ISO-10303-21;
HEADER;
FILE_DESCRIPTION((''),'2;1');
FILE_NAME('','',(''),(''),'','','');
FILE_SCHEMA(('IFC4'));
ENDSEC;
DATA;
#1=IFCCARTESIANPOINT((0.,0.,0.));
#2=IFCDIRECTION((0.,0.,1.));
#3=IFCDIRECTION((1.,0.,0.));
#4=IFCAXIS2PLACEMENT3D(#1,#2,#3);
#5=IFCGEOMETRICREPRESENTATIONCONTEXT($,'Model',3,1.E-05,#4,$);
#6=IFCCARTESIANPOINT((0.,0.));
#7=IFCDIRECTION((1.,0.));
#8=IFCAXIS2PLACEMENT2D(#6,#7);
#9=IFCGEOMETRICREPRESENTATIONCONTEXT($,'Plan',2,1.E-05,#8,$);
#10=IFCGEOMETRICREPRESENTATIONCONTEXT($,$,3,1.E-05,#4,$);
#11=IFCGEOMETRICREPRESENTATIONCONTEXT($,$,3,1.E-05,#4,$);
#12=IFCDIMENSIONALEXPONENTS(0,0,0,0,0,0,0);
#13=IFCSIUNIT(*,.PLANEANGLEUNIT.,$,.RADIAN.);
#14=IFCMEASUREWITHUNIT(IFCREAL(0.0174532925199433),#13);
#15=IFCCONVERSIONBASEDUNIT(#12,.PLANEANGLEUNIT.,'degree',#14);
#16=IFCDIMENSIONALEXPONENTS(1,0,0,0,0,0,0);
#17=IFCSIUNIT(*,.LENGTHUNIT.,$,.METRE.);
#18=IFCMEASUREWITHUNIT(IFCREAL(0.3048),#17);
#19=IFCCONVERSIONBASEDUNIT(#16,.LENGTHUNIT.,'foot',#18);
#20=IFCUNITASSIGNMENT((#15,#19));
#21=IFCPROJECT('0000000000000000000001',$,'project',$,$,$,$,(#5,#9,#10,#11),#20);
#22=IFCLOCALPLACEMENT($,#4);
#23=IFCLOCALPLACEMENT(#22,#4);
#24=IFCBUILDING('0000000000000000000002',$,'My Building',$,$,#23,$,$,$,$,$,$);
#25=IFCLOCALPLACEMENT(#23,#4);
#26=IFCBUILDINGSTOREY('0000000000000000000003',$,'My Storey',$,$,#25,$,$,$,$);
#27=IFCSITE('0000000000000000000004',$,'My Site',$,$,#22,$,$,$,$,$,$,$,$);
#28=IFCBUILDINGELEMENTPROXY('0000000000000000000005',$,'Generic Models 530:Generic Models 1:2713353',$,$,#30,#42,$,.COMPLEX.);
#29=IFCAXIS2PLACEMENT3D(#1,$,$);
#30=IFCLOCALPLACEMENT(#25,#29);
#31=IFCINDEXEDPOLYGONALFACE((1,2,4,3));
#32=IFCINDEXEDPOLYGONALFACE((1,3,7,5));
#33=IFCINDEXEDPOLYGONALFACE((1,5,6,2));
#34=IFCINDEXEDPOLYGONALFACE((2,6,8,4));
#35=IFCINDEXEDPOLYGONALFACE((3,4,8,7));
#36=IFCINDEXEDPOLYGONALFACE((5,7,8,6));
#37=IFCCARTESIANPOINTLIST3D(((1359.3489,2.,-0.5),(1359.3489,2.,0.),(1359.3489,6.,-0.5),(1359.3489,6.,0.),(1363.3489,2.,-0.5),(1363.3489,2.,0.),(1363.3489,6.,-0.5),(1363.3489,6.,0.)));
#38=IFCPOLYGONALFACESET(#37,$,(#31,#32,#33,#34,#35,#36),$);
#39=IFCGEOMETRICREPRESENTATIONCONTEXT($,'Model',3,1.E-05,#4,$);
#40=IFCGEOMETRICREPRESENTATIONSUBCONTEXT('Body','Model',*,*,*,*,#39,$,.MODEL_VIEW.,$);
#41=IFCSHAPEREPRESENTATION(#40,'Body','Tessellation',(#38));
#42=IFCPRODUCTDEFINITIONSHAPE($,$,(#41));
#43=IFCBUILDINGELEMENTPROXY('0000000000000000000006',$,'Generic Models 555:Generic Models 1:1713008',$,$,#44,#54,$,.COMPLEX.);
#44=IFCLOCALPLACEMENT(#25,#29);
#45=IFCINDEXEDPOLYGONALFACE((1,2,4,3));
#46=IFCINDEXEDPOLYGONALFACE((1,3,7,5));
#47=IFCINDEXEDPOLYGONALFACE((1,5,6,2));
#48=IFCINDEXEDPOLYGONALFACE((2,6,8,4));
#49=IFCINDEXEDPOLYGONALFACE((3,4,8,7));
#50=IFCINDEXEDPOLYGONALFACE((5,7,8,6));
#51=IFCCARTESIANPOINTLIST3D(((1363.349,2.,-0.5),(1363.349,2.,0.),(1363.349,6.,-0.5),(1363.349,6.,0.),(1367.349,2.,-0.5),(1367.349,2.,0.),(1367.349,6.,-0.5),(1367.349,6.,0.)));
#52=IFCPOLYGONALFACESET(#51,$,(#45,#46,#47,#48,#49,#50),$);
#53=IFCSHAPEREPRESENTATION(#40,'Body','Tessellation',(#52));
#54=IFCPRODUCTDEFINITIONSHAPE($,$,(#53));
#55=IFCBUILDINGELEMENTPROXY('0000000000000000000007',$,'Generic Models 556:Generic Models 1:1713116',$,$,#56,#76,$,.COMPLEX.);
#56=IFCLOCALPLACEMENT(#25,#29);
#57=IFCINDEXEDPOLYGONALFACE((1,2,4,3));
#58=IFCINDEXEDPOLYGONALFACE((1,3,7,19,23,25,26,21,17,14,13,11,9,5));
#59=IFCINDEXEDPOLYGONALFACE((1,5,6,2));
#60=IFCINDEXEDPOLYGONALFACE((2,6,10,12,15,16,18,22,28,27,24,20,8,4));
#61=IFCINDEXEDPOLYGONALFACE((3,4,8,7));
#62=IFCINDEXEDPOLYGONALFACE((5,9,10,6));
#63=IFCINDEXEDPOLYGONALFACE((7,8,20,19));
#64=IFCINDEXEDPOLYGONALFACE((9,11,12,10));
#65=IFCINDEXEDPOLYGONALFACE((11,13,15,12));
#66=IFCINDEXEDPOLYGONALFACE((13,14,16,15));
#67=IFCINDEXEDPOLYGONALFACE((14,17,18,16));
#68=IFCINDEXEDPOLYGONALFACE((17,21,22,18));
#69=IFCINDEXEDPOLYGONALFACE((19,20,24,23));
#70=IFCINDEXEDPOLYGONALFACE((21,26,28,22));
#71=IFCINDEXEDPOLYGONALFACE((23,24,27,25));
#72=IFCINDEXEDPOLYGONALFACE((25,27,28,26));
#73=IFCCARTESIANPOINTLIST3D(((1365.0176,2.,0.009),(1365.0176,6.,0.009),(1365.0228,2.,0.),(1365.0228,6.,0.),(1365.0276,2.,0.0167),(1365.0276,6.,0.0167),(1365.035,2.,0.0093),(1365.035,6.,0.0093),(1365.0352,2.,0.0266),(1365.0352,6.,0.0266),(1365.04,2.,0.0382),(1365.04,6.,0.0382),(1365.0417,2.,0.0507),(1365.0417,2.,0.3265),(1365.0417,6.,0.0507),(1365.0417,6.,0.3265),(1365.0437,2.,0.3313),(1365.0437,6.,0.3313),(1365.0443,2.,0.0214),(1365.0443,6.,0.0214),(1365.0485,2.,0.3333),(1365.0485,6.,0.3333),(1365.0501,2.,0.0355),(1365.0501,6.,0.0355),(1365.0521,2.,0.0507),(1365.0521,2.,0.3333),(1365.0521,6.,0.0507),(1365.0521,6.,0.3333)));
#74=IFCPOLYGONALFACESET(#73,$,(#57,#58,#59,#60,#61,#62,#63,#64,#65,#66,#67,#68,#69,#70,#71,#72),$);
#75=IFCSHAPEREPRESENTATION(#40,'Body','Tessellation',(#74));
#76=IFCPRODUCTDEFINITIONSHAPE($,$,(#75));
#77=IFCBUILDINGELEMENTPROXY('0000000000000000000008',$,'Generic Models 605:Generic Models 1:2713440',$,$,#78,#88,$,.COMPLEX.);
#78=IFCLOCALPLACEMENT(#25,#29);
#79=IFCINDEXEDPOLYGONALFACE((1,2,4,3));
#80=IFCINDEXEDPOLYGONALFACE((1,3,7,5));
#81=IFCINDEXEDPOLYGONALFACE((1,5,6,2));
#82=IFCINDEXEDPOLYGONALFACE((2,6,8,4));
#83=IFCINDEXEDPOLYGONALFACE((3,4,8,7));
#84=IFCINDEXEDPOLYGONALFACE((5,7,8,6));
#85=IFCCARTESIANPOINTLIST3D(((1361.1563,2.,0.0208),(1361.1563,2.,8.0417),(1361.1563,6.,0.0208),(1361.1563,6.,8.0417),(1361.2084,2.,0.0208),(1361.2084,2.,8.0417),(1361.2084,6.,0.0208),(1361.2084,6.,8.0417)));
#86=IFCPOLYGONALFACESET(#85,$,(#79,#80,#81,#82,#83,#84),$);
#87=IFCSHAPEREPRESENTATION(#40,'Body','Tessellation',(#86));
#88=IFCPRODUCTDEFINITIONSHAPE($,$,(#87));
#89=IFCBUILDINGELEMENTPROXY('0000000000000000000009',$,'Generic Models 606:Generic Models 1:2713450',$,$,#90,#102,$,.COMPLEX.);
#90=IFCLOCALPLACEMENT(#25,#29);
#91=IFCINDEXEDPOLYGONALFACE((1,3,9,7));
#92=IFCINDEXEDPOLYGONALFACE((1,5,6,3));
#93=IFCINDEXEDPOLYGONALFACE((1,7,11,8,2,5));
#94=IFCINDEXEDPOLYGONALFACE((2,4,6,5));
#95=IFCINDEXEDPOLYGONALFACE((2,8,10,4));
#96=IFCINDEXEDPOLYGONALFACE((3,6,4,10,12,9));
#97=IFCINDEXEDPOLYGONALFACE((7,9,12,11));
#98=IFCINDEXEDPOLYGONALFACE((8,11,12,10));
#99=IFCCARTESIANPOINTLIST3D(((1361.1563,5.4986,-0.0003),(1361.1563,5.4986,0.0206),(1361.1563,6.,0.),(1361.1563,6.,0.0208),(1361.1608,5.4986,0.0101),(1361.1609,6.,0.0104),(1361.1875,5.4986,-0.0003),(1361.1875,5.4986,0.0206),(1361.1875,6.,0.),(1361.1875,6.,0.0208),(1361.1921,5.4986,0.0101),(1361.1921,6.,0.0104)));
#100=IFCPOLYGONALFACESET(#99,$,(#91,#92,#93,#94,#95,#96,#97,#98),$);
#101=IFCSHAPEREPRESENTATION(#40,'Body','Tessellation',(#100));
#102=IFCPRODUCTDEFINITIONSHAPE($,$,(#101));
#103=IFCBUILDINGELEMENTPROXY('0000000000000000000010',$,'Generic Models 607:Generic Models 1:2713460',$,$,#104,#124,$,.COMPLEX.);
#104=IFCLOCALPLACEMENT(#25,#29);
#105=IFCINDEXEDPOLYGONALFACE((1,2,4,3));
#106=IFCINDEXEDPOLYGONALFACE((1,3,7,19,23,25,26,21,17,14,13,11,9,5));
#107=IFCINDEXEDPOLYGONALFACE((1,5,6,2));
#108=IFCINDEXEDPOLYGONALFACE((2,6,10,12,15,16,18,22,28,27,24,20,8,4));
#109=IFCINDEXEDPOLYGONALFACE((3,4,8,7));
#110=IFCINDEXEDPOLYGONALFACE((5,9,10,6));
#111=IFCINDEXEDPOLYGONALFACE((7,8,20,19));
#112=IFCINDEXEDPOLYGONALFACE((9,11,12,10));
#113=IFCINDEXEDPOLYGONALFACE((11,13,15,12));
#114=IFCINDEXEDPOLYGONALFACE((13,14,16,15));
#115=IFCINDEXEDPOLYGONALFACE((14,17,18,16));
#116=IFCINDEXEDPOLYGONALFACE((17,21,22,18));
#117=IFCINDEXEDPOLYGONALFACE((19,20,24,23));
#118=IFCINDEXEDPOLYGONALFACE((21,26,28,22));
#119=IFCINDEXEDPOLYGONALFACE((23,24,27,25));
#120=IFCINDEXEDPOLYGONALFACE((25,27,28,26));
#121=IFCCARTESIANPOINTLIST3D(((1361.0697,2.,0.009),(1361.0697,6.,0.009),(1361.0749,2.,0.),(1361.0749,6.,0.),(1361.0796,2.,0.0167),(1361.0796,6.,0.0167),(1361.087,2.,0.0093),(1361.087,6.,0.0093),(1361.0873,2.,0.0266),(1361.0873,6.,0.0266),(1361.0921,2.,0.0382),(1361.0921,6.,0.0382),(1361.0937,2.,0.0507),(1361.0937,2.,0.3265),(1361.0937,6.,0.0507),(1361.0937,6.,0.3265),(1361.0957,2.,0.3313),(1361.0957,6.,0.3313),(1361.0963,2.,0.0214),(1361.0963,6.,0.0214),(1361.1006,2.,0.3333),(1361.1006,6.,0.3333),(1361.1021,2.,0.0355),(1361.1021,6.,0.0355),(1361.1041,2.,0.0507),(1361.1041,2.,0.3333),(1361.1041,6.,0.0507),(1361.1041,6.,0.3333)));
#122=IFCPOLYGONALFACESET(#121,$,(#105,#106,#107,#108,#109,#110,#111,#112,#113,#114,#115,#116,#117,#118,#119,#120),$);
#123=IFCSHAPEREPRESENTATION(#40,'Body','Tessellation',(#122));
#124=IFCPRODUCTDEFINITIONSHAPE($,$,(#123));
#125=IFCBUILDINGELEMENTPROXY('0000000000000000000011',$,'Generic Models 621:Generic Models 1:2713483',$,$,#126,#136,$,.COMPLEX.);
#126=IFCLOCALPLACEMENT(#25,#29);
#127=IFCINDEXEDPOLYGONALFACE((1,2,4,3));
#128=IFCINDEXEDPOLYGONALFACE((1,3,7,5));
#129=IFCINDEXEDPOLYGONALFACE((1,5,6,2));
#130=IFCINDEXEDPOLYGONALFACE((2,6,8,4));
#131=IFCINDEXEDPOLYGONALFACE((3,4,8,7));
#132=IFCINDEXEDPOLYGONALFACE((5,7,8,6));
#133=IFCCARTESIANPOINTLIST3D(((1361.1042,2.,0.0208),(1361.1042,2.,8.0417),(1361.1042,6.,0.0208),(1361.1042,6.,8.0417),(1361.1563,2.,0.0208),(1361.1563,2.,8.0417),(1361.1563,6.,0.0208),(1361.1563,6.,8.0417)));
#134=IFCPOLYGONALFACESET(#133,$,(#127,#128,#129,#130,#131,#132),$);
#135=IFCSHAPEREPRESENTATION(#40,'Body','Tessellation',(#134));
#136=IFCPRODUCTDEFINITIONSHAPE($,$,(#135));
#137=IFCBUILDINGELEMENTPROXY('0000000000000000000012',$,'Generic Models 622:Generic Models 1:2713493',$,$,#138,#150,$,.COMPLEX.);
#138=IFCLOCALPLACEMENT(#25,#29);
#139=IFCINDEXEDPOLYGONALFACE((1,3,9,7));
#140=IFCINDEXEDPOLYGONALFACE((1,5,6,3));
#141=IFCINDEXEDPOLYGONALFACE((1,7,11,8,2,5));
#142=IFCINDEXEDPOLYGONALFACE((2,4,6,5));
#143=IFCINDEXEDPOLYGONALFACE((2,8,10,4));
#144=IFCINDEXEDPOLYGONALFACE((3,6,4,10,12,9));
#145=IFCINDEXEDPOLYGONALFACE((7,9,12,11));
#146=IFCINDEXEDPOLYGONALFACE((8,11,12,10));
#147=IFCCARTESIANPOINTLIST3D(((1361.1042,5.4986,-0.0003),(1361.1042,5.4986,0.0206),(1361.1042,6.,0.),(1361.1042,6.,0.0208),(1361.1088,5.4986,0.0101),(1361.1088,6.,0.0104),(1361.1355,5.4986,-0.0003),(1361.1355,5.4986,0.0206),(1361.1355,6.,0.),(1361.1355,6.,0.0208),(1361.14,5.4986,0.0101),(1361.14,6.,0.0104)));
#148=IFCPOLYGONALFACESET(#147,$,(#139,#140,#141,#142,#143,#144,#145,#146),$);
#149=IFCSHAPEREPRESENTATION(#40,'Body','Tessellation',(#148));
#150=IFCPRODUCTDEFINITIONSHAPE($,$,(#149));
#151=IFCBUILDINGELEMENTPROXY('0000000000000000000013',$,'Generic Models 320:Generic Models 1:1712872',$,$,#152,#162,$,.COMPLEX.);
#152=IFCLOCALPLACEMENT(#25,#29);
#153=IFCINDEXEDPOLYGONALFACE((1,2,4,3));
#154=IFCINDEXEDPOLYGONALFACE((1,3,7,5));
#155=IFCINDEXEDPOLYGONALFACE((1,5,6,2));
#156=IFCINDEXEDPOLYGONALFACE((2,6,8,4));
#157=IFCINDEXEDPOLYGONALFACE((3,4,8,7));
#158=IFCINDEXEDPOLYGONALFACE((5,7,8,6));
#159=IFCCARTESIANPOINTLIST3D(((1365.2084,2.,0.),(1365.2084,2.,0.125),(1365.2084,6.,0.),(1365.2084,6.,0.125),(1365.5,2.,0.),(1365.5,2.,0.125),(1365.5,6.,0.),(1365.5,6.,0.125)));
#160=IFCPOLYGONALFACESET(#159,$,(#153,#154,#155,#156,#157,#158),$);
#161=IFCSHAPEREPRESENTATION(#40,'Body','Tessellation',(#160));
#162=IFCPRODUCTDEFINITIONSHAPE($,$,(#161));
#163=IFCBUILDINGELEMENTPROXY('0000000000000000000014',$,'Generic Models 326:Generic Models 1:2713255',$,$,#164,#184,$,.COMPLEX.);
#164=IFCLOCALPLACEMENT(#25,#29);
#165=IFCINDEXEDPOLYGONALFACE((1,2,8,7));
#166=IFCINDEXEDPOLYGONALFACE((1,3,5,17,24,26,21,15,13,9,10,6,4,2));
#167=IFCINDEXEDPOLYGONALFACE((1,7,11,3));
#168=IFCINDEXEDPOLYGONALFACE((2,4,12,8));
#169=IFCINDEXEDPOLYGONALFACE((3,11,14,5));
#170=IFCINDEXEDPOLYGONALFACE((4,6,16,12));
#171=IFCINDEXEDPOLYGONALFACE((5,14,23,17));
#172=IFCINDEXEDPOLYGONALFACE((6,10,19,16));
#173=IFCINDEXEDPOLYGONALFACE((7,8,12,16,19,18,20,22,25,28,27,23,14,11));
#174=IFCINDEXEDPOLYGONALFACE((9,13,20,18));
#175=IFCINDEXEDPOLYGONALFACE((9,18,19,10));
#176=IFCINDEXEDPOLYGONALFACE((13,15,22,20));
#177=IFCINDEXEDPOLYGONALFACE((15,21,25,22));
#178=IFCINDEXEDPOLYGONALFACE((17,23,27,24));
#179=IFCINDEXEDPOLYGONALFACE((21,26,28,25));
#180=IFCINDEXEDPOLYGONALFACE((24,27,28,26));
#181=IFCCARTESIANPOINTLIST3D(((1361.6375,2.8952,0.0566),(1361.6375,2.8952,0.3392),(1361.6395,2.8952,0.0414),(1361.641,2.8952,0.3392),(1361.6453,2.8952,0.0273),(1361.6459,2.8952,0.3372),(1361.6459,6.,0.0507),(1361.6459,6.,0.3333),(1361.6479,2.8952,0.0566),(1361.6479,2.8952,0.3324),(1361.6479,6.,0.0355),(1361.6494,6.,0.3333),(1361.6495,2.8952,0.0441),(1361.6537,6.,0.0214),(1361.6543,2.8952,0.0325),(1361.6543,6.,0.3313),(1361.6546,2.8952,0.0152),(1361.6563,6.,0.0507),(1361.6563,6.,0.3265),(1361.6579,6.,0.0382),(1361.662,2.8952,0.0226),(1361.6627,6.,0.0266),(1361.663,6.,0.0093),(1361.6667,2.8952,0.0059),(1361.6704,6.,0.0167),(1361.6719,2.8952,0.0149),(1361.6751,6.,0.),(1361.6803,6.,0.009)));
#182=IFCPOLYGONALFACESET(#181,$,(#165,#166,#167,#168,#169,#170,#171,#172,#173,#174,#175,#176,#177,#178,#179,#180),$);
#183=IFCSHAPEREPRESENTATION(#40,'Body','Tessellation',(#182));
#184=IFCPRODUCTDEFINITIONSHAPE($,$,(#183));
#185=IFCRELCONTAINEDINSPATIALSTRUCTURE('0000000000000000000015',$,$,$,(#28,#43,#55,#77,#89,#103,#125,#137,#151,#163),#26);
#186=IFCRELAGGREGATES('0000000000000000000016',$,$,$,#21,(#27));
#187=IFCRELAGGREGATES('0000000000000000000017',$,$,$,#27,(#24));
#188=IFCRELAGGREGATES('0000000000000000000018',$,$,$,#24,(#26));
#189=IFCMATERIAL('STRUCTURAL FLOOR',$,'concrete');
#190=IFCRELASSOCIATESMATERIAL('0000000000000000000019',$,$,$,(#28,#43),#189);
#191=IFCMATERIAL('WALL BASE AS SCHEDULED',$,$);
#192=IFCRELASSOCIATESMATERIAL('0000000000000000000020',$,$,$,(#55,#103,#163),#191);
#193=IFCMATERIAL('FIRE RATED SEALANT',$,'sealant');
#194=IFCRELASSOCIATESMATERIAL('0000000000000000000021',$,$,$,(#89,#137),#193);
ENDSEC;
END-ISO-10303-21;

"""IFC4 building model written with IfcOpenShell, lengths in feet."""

from ifc_helpers import new_model, entity, si_unit, converted_unit, frame, origin_with_axes, origin_2d_with_axis, place, context, subcontext, project, spatial, polyline, outline, extrude, material, element, save


model = new_model("IFC4")

# Units and contexts
model_context_1 = context("Model", 3, precision=1e-05, world=origin_with_axes())
plan_context = context("Plan", 2, precision=1e-05, world=origin_2d_with_axis())
model_context_2 = context("Model", 3, precision=1e-05, world=origin_with_axes())
context_of_model_1 = context(None, 3, precision=1e-05, world=origin_with_axes())
context_of_model_2 = context(None, 3, precision=1e-05, world=origin_with_axes())
body_context = subcontext(model_context_2, "Body", "Model", "MODEL_VIEW")
ifc_project = project(units=[converted_unit("PLANEANGLEUNIT", "degree", entity("IfcReal", 0.0174532925199433), si_unit("PLANEANGLEUNIT", "RADIAN"), dimensions=[0, 0, 0, 0, 0, 0, 0]), converted_unit("LENGTHUNIT", "foot", entity("IfcReal", 0.3048), si_unit("LENGTHUNIT", "METRE"), dimensions=[1, 0, 0, 0, 0, 0, 0])], contexts=[model_context_1, plan_context, context_of_model_1, context_of_model_2])

# Site, building, storey
site_placement = place(None, origin_with_axes())
site = spatial("IfcSite", under=ifc_project, at=site_placement, Name="My Site")
building_placement = place(site_placement, origin_with_axes())
building = spatial("IfcBuilding", under=site, at=building_placement, Name="My Building")
storey_placement = place(building_placement, origin_with_axes())
storey = spatial("IfcBuildingStorey", under=building, at=storey_placement, Name="My Storey")

# Building element proxies
ifc_material_1 = material(Name="STRUCTURAL FLOOR", Category="concrete")
proxy_1_placement = place(storey_placement, frame((1359.3489, 6.0, -0.5), z_axis=(0.0, -1.0, 0.0), x_axis=(0.0, 0.0, 1.0)))
element("IfcBuildingElementProxy", 1, at=proxy_1_placement, inside=storey, material=ifc_material_1, Name="Generic Models 530:Generic Models 1:2713353", PredefinedType="COMPLEX", context=body_context, shape_type="SweptSolid", body=[
    extrude(outline(polyline([(-0.25, -2.0), (0.25, -2.0), (0.25, 2.0), (-0.25, 2.0), (-0.25, -2.0)])), frame((0.25, -2.0, 0.0), z_axis=(0.0, 0.0, -1.0), x_axis=(1.0, 0.0, 0.0)), (0.0, 0.0, -1.0), 4.0),
])
proxy_2_placement = place(storey_placement, frame((1363.349, 6.0, -0.5), z_axis=(0.0, -1.0, 0.0), x_axis=(0.0, 0.0, 1.0)))
element("IfcBuildingElementProxy", 2, at=proxy_2_placement, inside=storey, material=ifc_material_1, Name="Generic Models 555:Generic Models 1:1713008", PredefinedType="COMPLEX", context=body_context, shape_type="SweptSolid", body=[
    extrude(outline(polyline([(-0.25, -2.0), (0.25, -2.0), (0.25, 2.0), (-0.25, 2.0), (-0.25, -2.0)])), frame((0.25, -2.0, 0.0), z_axis=(0.0, 0.0, -1.0), x_axis=(1.0, 0.0, 0.0)), (0.0, 0.0, -1.0), 4.0),
])
ifc_material_2 = material(Name="WALL BASE AS SCHEDULED")
proxy_3_placement = place(storey_placement, frame((1365.0176, 6.0, 0.0), z_axis=(0.0, -1.0, 0.0), x_axis=(0.0, 0.0, 1.0)))
element("IfcBuildingElementProxy", 3, at=proxy_3_placement, inside=storey, material=ifc_material_2, Name="Generic Models 556:Generic Models 1:1713116", PredefinedType="COMPLEX", context=body_context, shape_type="SweptSolid", body=[
    extrude(outline(polyline([(0.2205, 0.0), (0.2206, 0.0036), (-0.0618, 0.0152), (-0.077, 0.0138), (-0.0914, 0.0086), (-0.1038, -0.0002), (-0.1136, -0.012), (-0.1048, -0.0175), (-0.0968, -0.0079), (-0.0865, -0.0007), (-0.0747, 0.0037), (-0.0622, 0.0048), (0.2133, -0.0066), (0.2183, -0.0048), (0.2205, 0.0)])), frame((0.113, -0.0218, 0.0), z_axis=(0.0, 0.0, -1.0), x_axis=(0.999153, -0.041137, 0.0)), (0.0, 0.0, -1.0), 4.0),
])
proxy_4_placement = place(storey_placement, frame((1361.1563, 6.0, 0.0208), z_axis=(0.0, -1.0, 0.0), x_axis=(0.0, 0.0, 1.0)))
element("IfcBuildingElementProxy", 4, at=proxy_4_placement, inside=storey, Name="Generic Models 605:Generic Models 1:2713440", PredefinedType="COMPLEX", context=body_context, shape_type="SweptSolid", body=[
    extrude(outline(polyline([(-0.026, -4.0104), (0.026, -4.0104), (0.026, 4.0104), (-0.026, 4.0104), (-0.026, -4.0104)])), frame((4.0104, -0.026, 0.0), z_axis=(0.0, 0.0, -1.0), x_axis=(0.0, 1.0, 0.0)), (0.0, 0.0, -1.0), 4.0),
])
ifc_material_3 = material(Name="FIRE RATED SEALANT", Category="sealant")
proxy_5_placement = place(storey_placement, frame((1361.1563, 6.0, 0.0), z_axis=(0.0, -1.0, 0.0), x_axis=(0.0, 0.0, 1.0)))
element("IfcBuildingElementProxy", 5, at=proxy_5_placement, inside=storey, material=ifc_material_3, Name="Generic Models 606:Generic Models 1:2713450", PredefinedType="COMPLEX", context=body_context, shape_type="SweptSolid", body=[
    extrude(outline(polyline([(0.0201, 0.0), (-0.0066, 0.0162), (-0.016, 0.0097), (-0.0175, -0.0016), (0.0093, -0.0178), (0.0107, -0.0065), (0.0201, 0.0)])), frame((0.0104, -0.0172, 0.0), z_axis=(0.0, 0.0, -1.0), x_axis=(0.51911, 0.854708, 0.0)), (-0.000285, -0.000479, -1.0), 0.5014),
])
proxy_6_placement = place(storey_placement, frame((1361.0697, 6.0, 0.0), z_axis=(0.0, -1.0, 0.0), x_axis=(0.0, 0.0, 1.0)))
element("IfcBuildingElementProxy", 6, at=proxy_6_placement, inside=storey, material=ifc_material_2, Name="Generic Models 607:Generic Models 1:2713460", PredefinedType="COMPLEX", context=body_context, shape_type="SweptSolid", body=[
    extrude(outline(polyline([(0.2205, 0.0), (0.2206, 0.0036), (-0.0618, 0.0152), (-0.077, 0.0138), (-0.0914, 0.0086), (-0.1038, -0.0002), (-0.1136, -0.012), (-0.1048, -0.0175), (-0.0968, -0.0079), (-0.0865, -0.0007), (-0.0747, 0.0037), (-0.0622, 0.0048), (0.2133, -0.0066), (0.2183, -0.0048), (0.2205, 0.0)])), frame((0.113, -0.0218, 0.0), z_axis=(0.0, 0.0, -1.0), x_axis=(0.999153, -0.041137, 0.0)), (0.0, 0.0, -1.0), 4.0),
])
proxy_7_placement = place(storey_placement, frame((1361.1042, 6.0, 0.0208), z_axis=(0.0, -1.0, 0.0), x_axis=(0.0, 0.0, 1.0)))
element("IfcBuildingElementProxy", 7, at=proxy_7_placement, inside=storey, Name="Generic Models 621:Generic Models 1:2713483", PredefinedType="COMPLEX", context=body_context, shape_type="SweptSolid", body=[
    extrude(outline(polyline([(-4.0104, -0.026), (4.0104, -0.026), (4.0104, 0.026), (-4.0104, 0.026), (-4.0104, -0.026)])), frame((4.0104, -0.026, 0.0), z_axis=(0.0, 0.0, -1.0), x_axis=(1.0, 0.0, 0.0)), (0.0, 0.0, -1.0), 4.0),
])
proxy_8_placement = place(storey_placement, frame((1361.1042, 6.0, 0.0), z_axis=(0.0, -1.0, 0.0), x_axis=(0.0, 0.0, 1.0)))
element("IfcBuildingElementProxy", 8, at=proxy_8_placement, inside=storey, material=ifc_material_3, Name="Generic Models 622:Generic Models 1:2713493", PredefinedType="COMPLEX", context=body_context, shape_type="SweptSolid", body=[
    extrude(outline(polyline([(0.0201, 0.0), (-0.0066, 0.0162), (-0.016, 0.0097), (-0.0175, -0.0016), (0.0093, -0.0178), (0.0107, -0.0065), (0.0201, 0.0)])), frame((0.0104, -0.0172, 0.0), z_axis=(0.0, 0.0, -1.0), x_axis=(0.51911, 0.854708, 0.0)), (-0.000285, -0.000479, -1.0), 0.5014),
])
proxy_9_placement = place(storey_placement, frame((1365.2084, 6.0, 0.0), z_axis=(0.0, -1.0, 0.0), x_axis=(0.0, 0.0, 1.0)))
element("IfcBuildingElementProxy", 9, at=proxy_9_placement, inside=storey, Name="Generic Models 320:Generic Models 1:1712872", PredefinedType="COMPLEX", context=body_context, shape_type="SweptSolid", body=[
    extrude(outline(polyline([(-0.0625, -0.1458), (0.0625, -0.1458), (0.0625, 0.1458), (-0.0625, 0.1458), (-0.0625, -0.1458)])), frame((0.0625, -0.1458, 0.0), z_axis=(0.0, 0.0, -1.0), x_axis=(1.0, 0.0, 0.0)), (0.0, 0.0, -1.0), 4.0),
])
proxy_10_placement = place(storey_placement, frame((1361.6459, 6.0, 0.0), z_axis=(0.0, -1.0, 0.0), x_axis=(0.0, 0.0, 1.0)))
element("IfcBuildingElementProxy", 10, at=proxy_10_placement, inside=storey, material=ifc_material_2, Name="Generic Models 326:Generic Models 1:2713255", PredefinedType="COMPLEX", context=body_context, shape_type="SweptSolid", body=[
    extrude(outline(polyline([(-0.2134, 0.0022), (0.0624, 0.0022), (0.0748, 0.0006), (0.0864, -0.0042), (0.0964, -0.0119), (0.104, -0.0218), (0.113, -0.0166), (0.1037, -0.0045), (0.0916, 0.0048), (0.0775, 0.0106), (0.0624, 0.0126), (-0.2203, 0.0126), (-0.2203, 0.0091), (-0.2183, 0.0042), (-0.2134, 0.0022)])), frame((0.113, -0.0126, 0.0), z_axis=(0.0, 0.0, -1.0), x_axis=(-1.0, 0.0, 0.0)), (-0.001902, 0.002712, -0.999995), 3.1048),
])

save(model, "model.ifc")
